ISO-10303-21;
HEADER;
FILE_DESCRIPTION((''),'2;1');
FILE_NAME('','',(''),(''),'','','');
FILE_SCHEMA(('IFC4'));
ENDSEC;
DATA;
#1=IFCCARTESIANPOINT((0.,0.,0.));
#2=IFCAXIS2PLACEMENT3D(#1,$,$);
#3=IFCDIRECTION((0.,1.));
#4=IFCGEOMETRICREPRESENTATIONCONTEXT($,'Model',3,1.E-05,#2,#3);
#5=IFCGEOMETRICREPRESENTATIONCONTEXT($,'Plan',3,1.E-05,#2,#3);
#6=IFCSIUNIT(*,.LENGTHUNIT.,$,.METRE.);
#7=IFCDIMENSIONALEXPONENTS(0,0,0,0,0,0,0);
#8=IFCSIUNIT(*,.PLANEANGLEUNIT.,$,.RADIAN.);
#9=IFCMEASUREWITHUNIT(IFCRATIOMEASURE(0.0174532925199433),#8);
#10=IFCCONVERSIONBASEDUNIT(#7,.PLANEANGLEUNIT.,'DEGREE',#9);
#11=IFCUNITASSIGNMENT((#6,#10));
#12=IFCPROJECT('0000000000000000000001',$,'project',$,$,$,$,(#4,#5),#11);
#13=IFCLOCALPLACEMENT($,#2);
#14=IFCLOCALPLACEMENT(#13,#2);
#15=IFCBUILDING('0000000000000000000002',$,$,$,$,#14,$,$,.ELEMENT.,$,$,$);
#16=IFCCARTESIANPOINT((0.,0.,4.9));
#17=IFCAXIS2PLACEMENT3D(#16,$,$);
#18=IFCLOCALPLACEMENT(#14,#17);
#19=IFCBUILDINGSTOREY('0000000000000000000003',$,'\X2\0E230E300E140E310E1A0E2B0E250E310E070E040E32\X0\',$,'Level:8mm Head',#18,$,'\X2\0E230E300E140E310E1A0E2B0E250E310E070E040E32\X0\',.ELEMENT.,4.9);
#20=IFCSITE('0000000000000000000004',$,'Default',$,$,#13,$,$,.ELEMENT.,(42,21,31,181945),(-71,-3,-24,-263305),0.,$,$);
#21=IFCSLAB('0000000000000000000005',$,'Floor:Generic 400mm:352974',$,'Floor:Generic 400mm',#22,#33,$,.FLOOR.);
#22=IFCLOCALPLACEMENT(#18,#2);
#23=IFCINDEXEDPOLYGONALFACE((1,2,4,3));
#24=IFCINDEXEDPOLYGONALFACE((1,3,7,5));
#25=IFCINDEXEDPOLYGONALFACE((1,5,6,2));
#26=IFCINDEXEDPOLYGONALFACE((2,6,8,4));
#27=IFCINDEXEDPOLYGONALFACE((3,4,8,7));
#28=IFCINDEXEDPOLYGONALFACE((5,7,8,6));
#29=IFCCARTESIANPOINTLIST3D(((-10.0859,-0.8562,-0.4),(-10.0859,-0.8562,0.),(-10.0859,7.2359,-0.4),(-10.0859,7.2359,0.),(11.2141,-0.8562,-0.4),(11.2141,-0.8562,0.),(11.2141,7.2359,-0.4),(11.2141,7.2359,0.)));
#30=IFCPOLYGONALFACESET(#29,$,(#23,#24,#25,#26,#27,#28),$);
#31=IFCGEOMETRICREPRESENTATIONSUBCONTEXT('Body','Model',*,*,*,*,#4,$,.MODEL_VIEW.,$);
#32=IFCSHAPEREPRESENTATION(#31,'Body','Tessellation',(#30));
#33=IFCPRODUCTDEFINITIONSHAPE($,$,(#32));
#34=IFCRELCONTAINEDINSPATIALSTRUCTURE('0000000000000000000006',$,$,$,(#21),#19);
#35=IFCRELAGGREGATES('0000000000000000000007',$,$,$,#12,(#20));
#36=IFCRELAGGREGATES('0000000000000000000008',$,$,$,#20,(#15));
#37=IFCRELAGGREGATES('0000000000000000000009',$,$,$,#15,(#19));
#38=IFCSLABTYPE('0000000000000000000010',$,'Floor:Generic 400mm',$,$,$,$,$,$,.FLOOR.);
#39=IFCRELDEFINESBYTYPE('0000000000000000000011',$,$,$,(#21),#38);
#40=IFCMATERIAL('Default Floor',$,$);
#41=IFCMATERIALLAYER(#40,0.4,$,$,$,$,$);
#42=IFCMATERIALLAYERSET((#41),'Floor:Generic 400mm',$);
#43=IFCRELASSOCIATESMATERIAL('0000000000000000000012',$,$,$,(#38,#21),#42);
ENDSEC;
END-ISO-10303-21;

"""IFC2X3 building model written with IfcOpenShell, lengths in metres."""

from ifc_helpers import new_model, entity, si_unit, converted_unit, direction, frame, frame_2d, origin, place, context, subcontext, project, spatial, rectangle, extrude, material, layer, layer_set, layer_usage, type_object, element, save


model = new_model("IFC2X3")

# Units and contexts
model_context = context("Model", 3, precision=1e-05, world=origin(), true_north=direction((0.0, 1.0)))
plan_context = context("Plan", 3, precision=1e-05, world=origin(), true_north=direction((0.0, 1.0)))
body_context = subcontext(model_context, "Body", "Model", "MODEL_VIEW")
ifc_project = project(units=[si_unit("LENGTHUNIT", "METRE"), converted_unit("PLANEANGLEUNIT", "DEGREE", entity("IfcRatioMeasure", 0.0174532925199433), si_unit("PLANEANGLEUNIT", "RADIAN"), dimensions=[0, 0, 0, 0, 0, 0, 0])], contexts=[model_context, plan_context])

# Site, building, storey
site_placement = place(None, origin())
site = spatial("IfcSite", under=ifc_project, at=site_placement, Name="Default", CompositionType="ELEMENT", RefLatitude=(42, 21, 31, 181945), RefLongitude=(-71, -3, -24, -263305), RefElevation=0.0)
building_placement = place(site_placement, origin())
building = spatial("IfcBuilding", under=site, at=building_placement, CompositionType="ELEMENT")
storey_placement = place(building_placement, frame((0.0, 0.0, 4.9)))
storey = spatial("IfcBuildingStorey", under=building, at=storey_placement, Name="ระดับหลังคา", ObjectType="Level:8mm Head", LongName="ระดับหลังคา", CompositionType="ELEMENT", Elevation=4.9)

# Slab
ifc_material = material(Name="Default Floor")
ifc_layer = layer(ifc_material, 0.4)
ifc_layer_set = layer_set([ifc_layer], Name="Floor:Generic 400mm")
ifc_layer_usage = layer_usage(ifc_layer_set, "AXIS3", "POSITIVE", 0.0)
slab_type = type_object("IfcSlabType", Name="Floor:Generic 400mm", PredefinedType="FLOOR", material=ifc_layer_set)
slab_placement = place(storey_placement, origin())
element("IfcSlab", 1, at=slab_placement, inside=storey, type_object=slab_type, material=ifc_layer_usage, Name="Floor:Generic 400mm:352974", ObjectType="Floor:Generic 400mm", PredefinedType="FLOOR", context=body_context, shape_type="SweptSolid", body=[
    extrude(rectangle(XDim=8.0921, YDim=21.3, at=frame_2d((0.0, 0.0), x_axis=(1.0, 0.0))), frame((0.5641, 3.1898, 0.0), z_axis=(0.0, 0.0, -1.0), x_axis=(0.0, 1.0, 0.0)), (0.0, 0.0, 1.0), 0.4),
])

save(model, "model.ifc")
